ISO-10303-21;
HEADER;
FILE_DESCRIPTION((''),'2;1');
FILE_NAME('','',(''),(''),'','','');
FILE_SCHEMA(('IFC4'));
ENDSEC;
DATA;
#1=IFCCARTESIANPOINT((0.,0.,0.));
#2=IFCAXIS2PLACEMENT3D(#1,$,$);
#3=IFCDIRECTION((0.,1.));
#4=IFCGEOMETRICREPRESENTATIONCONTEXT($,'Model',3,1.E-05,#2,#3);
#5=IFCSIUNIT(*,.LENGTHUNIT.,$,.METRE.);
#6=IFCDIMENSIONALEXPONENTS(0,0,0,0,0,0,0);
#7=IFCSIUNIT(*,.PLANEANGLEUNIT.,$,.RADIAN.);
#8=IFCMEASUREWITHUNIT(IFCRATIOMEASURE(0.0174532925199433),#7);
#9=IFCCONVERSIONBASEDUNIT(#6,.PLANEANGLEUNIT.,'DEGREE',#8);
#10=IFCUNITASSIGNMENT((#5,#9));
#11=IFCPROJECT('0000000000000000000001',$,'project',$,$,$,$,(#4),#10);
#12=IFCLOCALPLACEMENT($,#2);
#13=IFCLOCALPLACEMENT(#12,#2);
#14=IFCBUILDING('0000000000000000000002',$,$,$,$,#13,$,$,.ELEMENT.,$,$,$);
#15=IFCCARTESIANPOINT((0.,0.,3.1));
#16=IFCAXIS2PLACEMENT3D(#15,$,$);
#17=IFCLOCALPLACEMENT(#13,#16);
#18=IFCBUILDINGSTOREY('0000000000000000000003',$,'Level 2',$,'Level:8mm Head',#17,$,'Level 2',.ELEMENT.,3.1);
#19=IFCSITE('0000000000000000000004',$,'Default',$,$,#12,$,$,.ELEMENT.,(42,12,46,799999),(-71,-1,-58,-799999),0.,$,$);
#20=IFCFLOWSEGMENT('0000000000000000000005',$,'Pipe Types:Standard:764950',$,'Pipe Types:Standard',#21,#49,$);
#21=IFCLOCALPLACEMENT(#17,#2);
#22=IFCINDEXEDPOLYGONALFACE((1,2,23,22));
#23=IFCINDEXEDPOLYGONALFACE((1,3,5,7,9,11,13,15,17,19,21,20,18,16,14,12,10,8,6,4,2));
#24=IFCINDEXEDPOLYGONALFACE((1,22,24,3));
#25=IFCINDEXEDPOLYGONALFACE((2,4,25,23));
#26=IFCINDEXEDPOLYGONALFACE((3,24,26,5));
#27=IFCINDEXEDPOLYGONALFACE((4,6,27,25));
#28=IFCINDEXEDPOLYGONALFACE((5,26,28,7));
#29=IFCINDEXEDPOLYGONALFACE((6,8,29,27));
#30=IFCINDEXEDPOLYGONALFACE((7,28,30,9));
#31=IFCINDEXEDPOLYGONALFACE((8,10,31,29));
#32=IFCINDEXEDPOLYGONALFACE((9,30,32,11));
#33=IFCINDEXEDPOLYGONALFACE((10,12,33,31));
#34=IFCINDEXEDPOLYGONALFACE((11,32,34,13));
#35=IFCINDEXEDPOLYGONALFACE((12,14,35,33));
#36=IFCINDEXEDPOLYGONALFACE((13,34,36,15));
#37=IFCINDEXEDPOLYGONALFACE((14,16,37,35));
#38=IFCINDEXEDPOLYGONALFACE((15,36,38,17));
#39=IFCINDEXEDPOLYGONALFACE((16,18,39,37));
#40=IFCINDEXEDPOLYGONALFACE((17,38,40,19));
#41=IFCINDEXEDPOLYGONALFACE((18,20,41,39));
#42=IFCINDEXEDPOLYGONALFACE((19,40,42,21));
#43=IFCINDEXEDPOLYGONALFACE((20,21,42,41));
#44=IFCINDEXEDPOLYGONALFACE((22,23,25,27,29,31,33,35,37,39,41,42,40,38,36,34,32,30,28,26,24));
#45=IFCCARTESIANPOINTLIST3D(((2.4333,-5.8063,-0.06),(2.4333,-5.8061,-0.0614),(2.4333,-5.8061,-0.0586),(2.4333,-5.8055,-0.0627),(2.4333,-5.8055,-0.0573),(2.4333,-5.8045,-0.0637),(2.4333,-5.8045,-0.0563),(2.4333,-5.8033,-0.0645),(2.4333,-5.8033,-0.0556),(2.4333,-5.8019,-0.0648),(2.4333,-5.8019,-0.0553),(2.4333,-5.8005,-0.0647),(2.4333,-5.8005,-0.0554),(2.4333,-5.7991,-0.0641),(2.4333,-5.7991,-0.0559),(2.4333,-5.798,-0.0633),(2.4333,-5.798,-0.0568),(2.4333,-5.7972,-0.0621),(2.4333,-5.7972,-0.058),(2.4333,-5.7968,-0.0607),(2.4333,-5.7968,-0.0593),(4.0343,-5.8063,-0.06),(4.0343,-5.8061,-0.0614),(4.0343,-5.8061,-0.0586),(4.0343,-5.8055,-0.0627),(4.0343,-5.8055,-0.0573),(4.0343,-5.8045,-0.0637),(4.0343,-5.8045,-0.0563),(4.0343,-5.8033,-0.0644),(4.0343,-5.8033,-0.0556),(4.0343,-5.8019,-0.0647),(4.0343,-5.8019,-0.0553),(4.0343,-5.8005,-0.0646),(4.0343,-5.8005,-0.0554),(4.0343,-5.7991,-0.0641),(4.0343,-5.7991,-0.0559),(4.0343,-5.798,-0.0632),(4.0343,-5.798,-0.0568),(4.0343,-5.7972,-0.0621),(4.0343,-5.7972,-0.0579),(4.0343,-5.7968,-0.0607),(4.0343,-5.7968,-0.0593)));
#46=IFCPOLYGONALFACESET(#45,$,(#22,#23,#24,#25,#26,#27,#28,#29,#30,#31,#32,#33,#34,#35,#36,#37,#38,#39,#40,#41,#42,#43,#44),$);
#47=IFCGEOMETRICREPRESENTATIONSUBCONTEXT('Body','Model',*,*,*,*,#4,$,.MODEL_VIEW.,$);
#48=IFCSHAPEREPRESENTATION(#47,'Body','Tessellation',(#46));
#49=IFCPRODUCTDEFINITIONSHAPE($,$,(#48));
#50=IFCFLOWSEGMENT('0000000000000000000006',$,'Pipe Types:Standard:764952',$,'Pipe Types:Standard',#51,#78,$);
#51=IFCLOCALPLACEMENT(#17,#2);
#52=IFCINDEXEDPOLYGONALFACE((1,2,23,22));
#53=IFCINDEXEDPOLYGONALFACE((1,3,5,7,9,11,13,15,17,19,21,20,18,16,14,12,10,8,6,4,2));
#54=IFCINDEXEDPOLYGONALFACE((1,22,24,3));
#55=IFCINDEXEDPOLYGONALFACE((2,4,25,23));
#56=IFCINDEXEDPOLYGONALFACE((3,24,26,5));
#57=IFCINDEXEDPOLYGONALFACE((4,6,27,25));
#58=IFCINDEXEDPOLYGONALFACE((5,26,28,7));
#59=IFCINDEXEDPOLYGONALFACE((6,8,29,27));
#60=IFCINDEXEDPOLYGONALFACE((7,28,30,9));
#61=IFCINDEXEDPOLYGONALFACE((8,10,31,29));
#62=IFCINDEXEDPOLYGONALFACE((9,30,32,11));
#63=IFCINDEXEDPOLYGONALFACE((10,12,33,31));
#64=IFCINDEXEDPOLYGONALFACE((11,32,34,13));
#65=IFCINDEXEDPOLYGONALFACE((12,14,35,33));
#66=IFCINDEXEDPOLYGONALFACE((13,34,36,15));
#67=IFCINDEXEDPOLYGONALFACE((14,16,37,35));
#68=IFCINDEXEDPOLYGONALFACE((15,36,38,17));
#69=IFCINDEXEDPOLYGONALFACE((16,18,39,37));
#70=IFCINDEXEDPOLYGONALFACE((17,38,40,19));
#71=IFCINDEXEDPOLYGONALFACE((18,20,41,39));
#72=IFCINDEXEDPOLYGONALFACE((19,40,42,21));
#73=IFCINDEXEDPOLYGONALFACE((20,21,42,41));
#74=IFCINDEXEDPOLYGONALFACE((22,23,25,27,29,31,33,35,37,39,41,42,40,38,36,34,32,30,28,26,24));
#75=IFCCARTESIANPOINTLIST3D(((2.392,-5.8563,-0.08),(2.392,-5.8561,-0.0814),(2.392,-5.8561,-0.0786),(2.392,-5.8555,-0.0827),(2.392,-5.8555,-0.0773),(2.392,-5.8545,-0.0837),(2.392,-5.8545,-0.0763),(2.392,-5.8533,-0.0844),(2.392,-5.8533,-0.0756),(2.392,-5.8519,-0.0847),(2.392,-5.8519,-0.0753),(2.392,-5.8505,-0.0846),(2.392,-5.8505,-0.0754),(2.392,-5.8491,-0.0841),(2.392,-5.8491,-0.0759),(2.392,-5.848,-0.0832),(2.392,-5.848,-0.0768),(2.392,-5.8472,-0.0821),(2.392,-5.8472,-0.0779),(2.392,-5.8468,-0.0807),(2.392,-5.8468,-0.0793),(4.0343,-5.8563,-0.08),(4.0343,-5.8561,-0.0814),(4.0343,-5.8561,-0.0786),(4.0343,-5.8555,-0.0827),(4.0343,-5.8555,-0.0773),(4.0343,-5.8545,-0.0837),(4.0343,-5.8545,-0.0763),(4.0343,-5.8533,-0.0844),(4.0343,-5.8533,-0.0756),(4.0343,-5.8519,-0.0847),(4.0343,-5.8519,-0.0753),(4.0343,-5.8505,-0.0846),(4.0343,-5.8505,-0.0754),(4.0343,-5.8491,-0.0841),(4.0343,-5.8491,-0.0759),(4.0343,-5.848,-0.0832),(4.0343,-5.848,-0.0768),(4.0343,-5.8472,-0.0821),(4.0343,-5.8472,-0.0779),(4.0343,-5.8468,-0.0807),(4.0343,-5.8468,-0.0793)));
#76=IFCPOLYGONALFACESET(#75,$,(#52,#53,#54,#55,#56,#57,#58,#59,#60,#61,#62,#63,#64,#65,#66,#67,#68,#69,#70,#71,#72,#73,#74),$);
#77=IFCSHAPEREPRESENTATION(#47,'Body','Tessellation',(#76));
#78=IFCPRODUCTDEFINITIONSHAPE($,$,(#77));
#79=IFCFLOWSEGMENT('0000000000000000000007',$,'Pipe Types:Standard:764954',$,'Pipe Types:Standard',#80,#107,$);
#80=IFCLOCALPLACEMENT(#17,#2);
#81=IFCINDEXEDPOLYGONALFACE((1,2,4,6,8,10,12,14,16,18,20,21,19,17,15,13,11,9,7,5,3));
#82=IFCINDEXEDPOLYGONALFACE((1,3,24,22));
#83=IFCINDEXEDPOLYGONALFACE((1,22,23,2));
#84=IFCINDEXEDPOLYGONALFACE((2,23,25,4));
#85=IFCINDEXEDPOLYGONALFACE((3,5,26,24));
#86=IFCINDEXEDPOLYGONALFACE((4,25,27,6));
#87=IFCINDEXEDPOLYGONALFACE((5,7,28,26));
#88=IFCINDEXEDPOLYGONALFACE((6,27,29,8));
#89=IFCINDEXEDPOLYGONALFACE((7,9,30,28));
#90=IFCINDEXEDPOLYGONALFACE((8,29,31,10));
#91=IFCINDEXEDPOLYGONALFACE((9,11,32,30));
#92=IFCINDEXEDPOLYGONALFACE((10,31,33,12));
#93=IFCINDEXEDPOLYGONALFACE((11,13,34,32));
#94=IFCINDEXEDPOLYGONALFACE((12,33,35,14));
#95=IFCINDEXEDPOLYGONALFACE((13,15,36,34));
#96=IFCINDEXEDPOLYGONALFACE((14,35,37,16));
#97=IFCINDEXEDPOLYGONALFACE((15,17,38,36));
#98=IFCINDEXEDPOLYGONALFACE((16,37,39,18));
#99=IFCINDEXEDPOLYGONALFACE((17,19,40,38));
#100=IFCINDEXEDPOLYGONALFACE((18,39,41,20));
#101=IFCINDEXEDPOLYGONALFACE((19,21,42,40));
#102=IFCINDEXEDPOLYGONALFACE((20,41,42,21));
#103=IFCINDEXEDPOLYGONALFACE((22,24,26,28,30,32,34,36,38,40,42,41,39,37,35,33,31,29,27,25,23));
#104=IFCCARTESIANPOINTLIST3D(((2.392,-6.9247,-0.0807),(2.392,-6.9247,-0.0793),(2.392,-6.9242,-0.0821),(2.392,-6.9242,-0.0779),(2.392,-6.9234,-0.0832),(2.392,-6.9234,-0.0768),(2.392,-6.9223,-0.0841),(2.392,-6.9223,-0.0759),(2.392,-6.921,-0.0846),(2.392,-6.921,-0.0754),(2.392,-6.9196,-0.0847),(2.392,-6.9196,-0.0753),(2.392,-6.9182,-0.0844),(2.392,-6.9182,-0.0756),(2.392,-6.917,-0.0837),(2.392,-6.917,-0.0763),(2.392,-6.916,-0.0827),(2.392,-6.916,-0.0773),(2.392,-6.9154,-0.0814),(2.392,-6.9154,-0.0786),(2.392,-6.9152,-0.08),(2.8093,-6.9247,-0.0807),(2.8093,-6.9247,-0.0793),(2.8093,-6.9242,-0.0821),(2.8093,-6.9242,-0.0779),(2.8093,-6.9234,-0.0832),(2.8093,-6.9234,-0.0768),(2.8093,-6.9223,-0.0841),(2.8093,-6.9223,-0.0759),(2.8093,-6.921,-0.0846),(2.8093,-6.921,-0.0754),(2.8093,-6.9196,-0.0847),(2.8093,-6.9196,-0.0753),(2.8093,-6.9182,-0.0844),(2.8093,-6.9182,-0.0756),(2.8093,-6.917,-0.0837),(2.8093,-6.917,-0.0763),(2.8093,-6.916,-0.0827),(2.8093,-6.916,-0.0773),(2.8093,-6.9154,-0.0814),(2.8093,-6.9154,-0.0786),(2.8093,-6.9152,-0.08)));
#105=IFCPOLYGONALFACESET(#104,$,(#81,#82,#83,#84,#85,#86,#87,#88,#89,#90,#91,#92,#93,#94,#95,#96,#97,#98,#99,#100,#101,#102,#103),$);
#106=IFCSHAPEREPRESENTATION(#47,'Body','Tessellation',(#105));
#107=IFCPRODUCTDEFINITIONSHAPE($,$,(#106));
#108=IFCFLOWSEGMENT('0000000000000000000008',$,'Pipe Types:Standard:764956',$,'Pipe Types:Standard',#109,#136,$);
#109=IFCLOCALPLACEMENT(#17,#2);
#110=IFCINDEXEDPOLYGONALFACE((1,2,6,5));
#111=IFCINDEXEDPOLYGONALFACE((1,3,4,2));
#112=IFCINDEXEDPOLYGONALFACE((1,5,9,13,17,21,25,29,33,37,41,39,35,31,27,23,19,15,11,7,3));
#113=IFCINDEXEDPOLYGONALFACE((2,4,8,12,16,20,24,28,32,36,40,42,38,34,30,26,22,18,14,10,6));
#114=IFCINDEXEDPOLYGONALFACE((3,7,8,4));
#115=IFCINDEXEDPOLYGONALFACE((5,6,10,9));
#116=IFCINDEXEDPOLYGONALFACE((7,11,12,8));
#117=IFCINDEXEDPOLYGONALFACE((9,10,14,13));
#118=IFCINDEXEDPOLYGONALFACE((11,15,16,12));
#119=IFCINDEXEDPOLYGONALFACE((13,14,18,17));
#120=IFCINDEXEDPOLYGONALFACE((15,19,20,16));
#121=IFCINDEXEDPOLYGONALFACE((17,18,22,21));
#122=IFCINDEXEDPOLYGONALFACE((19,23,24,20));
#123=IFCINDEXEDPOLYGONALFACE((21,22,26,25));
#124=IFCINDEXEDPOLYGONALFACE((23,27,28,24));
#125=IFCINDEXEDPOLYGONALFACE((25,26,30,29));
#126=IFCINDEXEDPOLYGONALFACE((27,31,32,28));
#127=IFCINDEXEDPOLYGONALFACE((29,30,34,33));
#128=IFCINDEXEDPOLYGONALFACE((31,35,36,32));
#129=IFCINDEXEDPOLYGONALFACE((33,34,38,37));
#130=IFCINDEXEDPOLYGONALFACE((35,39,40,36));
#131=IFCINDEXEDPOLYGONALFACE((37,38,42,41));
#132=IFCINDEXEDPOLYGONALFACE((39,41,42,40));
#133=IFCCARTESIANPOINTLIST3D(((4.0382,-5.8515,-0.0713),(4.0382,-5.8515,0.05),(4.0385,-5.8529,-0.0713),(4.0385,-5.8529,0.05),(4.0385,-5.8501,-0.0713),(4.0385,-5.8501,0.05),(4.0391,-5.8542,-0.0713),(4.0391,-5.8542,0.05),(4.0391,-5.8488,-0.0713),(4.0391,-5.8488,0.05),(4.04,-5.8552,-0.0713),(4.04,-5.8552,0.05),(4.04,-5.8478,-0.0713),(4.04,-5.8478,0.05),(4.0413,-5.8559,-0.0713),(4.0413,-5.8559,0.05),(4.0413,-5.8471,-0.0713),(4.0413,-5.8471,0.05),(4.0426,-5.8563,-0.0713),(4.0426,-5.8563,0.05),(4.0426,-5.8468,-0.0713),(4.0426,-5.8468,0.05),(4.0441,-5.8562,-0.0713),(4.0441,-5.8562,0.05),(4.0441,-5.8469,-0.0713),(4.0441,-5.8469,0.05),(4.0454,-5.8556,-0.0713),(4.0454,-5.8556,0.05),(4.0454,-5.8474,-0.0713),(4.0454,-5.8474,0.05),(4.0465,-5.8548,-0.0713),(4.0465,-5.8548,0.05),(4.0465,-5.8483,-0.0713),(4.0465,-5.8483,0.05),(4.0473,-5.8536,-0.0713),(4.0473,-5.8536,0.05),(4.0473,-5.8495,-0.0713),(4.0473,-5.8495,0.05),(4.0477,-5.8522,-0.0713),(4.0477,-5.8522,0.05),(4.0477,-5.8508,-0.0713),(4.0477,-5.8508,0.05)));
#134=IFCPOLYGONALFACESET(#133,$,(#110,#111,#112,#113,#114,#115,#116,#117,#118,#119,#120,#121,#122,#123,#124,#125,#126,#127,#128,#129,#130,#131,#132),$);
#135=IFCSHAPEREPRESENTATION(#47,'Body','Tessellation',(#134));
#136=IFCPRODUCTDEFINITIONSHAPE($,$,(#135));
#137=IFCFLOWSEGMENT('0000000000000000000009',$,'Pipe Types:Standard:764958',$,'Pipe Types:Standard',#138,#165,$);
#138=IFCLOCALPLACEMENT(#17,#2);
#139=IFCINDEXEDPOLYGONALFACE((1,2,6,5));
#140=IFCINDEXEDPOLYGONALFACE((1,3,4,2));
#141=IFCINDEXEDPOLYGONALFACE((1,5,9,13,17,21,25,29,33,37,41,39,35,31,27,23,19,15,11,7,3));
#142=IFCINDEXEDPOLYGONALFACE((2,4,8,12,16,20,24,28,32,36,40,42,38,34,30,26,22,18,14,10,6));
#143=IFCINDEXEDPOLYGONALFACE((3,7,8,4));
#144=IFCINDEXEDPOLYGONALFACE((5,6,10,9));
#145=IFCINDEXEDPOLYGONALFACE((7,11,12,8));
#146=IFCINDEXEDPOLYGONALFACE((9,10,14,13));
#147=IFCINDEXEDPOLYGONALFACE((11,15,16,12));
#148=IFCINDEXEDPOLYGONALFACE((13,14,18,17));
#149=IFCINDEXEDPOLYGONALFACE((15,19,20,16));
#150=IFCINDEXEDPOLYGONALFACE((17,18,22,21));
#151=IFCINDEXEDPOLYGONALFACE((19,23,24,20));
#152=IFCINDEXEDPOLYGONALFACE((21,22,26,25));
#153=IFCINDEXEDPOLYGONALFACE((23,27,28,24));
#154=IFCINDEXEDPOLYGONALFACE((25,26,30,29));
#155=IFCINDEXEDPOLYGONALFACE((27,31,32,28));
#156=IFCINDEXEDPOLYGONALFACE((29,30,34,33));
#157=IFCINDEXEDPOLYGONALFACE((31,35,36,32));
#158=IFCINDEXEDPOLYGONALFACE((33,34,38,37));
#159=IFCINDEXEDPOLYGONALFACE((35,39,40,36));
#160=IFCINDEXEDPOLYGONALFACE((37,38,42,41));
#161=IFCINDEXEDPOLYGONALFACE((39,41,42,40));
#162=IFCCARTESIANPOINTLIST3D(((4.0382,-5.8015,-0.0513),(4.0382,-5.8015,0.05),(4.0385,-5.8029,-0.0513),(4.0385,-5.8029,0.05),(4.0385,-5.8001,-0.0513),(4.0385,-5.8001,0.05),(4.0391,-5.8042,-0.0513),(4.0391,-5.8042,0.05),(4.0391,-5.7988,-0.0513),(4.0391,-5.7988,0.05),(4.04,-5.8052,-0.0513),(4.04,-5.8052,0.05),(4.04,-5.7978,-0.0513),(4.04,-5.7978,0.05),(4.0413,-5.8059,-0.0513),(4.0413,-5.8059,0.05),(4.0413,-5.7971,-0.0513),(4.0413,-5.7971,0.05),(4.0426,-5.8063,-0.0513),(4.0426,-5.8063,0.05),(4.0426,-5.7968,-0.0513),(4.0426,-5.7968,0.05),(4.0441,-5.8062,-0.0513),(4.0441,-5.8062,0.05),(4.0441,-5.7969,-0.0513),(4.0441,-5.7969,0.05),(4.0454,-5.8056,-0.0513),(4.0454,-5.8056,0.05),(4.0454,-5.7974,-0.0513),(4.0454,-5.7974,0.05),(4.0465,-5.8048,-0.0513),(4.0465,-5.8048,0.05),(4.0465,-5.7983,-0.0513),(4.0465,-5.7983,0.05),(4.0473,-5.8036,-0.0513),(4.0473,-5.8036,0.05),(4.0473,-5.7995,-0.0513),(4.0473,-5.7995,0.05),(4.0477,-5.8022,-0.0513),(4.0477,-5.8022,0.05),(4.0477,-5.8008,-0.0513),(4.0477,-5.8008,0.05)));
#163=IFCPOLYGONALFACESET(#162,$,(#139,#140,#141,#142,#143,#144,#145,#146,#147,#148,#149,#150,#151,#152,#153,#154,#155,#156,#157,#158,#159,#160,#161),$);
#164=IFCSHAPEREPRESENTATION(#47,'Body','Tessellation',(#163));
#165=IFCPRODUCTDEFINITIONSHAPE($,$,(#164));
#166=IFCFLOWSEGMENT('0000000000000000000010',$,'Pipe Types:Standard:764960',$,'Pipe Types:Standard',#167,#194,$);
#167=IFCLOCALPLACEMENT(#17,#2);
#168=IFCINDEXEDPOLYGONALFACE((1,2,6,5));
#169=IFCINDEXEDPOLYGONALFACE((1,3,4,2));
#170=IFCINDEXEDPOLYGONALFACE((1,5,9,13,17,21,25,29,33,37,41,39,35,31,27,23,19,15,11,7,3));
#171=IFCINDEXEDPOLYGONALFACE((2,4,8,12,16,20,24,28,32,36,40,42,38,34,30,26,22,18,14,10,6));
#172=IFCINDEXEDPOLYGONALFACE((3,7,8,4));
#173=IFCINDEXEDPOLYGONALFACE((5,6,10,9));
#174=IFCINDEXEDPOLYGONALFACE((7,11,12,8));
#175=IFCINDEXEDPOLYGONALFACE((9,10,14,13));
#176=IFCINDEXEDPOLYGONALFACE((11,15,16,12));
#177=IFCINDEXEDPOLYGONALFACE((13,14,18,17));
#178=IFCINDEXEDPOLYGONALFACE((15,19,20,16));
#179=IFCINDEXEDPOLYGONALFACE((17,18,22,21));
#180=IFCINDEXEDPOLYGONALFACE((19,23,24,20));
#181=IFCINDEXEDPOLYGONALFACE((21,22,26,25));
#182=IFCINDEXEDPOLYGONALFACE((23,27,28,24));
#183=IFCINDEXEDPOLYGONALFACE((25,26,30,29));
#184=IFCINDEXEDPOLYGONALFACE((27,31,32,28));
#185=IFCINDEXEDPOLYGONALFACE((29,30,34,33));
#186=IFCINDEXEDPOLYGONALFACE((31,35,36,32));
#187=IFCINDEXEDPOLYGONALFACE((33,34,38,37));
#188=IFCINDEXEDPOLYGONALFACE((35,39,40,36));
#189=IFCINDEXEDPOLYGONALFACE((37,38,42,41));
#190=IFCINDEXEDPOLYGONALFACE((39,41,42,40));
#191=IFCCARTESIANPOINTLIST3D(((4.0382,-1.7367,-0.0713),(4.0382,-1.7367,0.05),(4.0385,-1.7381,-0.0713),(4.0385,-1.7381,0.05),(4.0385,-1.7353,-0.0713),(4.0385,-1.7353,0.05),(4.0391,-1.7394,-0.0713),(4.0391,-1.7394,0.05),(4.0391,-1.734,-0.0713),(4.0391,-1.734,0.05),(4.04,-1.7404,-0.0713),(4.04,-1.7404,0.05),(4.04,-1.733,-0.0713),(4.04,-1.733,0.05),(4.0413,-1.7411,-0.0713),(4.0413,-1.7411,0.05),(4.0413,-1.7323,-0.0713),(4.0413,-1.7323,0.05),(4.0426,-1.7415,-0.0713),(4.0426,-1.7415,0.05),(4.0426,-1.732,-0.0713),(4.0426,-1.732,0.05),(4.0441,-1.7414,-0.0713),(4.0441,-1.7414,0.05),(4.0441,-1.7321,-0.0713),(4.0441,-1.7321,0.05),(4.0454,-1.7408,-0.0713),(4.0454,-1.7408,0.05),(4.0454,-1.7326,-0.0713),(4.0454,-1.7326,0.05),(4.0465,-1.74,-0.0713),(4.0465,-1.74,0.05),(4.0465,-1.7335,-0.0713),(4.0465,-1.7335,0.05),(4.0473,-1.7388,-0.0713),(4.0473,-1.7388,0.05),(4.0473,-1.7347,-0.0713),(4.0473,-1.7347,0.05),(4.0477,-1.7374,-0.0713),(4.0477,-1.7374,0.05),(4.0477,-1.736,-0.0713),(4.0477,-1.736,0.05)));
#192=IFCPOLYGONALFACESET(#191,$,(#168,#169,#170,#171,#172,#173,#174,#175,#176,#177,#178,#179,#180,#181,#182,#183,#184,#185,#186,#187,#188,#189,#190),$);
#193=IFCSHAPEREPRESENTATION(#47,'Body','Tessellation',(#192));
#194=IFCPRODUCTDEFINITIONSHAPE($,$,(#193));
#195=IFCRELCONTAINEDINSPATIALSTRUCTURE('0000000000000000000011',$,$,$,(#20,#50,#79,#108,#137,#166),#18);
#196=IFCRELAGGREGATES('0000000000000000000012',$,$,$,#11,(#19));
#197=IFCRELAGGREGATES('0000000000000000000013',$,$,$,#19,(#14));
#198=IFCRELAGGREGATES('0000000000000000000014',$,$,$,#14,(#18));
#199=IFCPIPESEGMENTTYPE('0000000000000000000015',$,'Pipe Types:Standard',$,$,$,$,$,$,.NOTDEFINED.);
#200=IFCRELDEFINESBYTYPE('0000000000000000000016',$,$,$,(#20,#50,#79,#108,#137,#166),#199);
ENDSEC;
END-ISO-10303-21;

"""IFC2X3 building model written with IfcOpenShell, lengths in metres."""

from ifc_helpers import new_model, entity, si_unit, converted_unit, direction, frame, frame_2d, origin, origin_2d_with_axis, place, context, subcontext, project, spatial, circle, extrude, type_object, element, save


model = new_model("IFC2X3")

# Units and contexts
model_context = context("Model", 3, precision=1e-05, world=origin(), true_north=direction((0.0, 1.0)))
body_context = subcontext(model_context, "Body", "Model", "MODEL_VIEW")
ifc_project = project(units=[si_unit("LENGTHUNIT", "METRE"), converted_unit("PLANEANGLEUNIT", "DEGREE", entity("IfcRatioMeasure", 0.0174532925199433), si_unit("PLANEANGLEUNIT", "RADIAN"), dimensions=[0, 0, 0, 0, 0, 0, 0])], contexts=[model_context])

# Site, building, storey
site_placement = place(None, origin())
site = spatial("IfcSite", under=ifc_project, at=site_placement, Name="Default", CompositionType="ELEMENT", RefLatitude=(42, 12, 46, 799999), RefLongitude=(-71, -1, -58, -799999), RefElevation=0.0)
building_placement = place(site_placement, origin())
building = spatial("IfcBuilding", under=site, at=building_placement, CompositionType="ELEMENT")
storey_placement = place(building_placement, frame((0.0, 0.0, 3.1)))
storey = spatial("IfcBuildingStorey", under=building, at=storey_placement, Name="Level 2", ObjectType="Level:8mm Head", LongName="Level 2", CompositionType="ELEMENT", Elevation=3.1)

# Flow segments
pipe_segment_type = type_object("IfcPipeSegmentType", Name="Pipe Types:Standard", PredefinedType="NOTDEFINED")
flow_segment_1_placement = place(storey_placement, origin())
element("IfcFlowSegment", 1, at=flow_segment_1_placement, inside=storey, type_object=pipe_segment_type, Name="Pipe Types:Standard:764950", ObjectType="Pipe Types:Standard", context=body_context, shape_type="SweptSolid", body=[
    extrude(circle(Radius=0.0048, at=origin_2d_with_axis()), frame((2.4333, -5.8015, -0.06), z_axis=(1.0, 0.0, 0.000015), x_axis=(0.0, -1.0, 0.0)), (0.0, 0.0, 1.0), 1.601),
])
flow_segment_2_placement = place(storey_placement, origin())
element("IfcFlowSegment", 2, at=flow_segment_2_placement, inside=storey, type_object=pipe_segment_type, Name="Pipe Types:Standard:764952", ObjectType="Pipe Types:Standard", context=body_context, shape_type="SweptSolid", body=[
    extrude(circle(Radius=0.0048, at=origin_2d_with_axis()), frame((2.392, -5.8515, -0.08), z_axis=(1.0, 0.0, 0.0), x_axis=(0.0, -1.0, 0.0)), (0.0, 0.0, 1.0), 1.6423),
])
flow_segment_3_placement = place(storey_placement, origin())
element("IfcFlowSegment", 3, at=flow_segment_3_placement, inside=storey, type_object=pipe_segment_type, Name="Pipe Types:Standard:764954", ObjectType="Pipe Types:Standard", context=body_context, shape_type="SweptSolid", body=[
    extrude(circle(Radius=0.0048, at=frame_2d((0.0, 0.0), x_axis=(1.0, 0.0))), frame((2.392, -6.9199, -0.08), z_axis=(1.0, 0.0, 0.0), x_axis=(0.0, 1.0, 0.0)), (0.0, 0.0, 1.0), 0.4173),
])
flow_segment_4_placement = place(storey_placement, origin())
element("IfcFlowSegment", 4, at=flow_segment_4_placement, inside=storey, type_object=pipe_segment_type, Name="Pipe Types:Standard:764956", ObjectType="Pipe Types:Standard", context=body_context, shape_type="SweptSolid", body=[
    extrude(circle(Radius=0.0048, at=origin_2d_with_axis()), frame((4.043, -5.8515, -0.0713), z_axis=(0.0, 0.0, 1.0), x_axis=(-1.0, 0.0, 0.0)), (0.0, 0.0, 1.0), 0.1213),
])
flow_segment_5_placement = place(storey_placement, origin())
element("IfcFlowSegment", 5, at=flow_segment_5_placement, inside=storey, type_object=pipe_segment_type, Name="Pipe Types:Standard:764958", ObjectType="Pipe Types:Standard", context=body_context, shape_type="SweptSolid", body=[
    extrude(circle(Radius=0.0048, at=origin_2d_with_axis()), frame((4.043, -5.8015, -0.0513), z_axis=(0.0, 0.0, 1.0), x_axis=(-1.0, 0.0, 0.0)), (0.0, 0.0, 1.0), 0.1013),
])
flow_segment_6_placement = place(storey_placement, origin())
element("IfcFlowSegment", 6, at=flow_segment_6_placement, inside=storey, type_object=pipe_segment_type, Name="Pipe Types:Standard:764960", ObjectType="Pipe Types:Standard", context=body_context, shape_type="SweptSolid", body=[
    extrude(circle(Radius=0.0048, at=origin_2d_with_axis()), frame((4.043, -1.7367, -0.0713), z_axis=(0.0, 0.0, 1.0), x_axis=(-1.0, 0.0, 0.0)), (0.0, 0.0, 1.0), 0.1213),
])

save(model, "model.ifc")
